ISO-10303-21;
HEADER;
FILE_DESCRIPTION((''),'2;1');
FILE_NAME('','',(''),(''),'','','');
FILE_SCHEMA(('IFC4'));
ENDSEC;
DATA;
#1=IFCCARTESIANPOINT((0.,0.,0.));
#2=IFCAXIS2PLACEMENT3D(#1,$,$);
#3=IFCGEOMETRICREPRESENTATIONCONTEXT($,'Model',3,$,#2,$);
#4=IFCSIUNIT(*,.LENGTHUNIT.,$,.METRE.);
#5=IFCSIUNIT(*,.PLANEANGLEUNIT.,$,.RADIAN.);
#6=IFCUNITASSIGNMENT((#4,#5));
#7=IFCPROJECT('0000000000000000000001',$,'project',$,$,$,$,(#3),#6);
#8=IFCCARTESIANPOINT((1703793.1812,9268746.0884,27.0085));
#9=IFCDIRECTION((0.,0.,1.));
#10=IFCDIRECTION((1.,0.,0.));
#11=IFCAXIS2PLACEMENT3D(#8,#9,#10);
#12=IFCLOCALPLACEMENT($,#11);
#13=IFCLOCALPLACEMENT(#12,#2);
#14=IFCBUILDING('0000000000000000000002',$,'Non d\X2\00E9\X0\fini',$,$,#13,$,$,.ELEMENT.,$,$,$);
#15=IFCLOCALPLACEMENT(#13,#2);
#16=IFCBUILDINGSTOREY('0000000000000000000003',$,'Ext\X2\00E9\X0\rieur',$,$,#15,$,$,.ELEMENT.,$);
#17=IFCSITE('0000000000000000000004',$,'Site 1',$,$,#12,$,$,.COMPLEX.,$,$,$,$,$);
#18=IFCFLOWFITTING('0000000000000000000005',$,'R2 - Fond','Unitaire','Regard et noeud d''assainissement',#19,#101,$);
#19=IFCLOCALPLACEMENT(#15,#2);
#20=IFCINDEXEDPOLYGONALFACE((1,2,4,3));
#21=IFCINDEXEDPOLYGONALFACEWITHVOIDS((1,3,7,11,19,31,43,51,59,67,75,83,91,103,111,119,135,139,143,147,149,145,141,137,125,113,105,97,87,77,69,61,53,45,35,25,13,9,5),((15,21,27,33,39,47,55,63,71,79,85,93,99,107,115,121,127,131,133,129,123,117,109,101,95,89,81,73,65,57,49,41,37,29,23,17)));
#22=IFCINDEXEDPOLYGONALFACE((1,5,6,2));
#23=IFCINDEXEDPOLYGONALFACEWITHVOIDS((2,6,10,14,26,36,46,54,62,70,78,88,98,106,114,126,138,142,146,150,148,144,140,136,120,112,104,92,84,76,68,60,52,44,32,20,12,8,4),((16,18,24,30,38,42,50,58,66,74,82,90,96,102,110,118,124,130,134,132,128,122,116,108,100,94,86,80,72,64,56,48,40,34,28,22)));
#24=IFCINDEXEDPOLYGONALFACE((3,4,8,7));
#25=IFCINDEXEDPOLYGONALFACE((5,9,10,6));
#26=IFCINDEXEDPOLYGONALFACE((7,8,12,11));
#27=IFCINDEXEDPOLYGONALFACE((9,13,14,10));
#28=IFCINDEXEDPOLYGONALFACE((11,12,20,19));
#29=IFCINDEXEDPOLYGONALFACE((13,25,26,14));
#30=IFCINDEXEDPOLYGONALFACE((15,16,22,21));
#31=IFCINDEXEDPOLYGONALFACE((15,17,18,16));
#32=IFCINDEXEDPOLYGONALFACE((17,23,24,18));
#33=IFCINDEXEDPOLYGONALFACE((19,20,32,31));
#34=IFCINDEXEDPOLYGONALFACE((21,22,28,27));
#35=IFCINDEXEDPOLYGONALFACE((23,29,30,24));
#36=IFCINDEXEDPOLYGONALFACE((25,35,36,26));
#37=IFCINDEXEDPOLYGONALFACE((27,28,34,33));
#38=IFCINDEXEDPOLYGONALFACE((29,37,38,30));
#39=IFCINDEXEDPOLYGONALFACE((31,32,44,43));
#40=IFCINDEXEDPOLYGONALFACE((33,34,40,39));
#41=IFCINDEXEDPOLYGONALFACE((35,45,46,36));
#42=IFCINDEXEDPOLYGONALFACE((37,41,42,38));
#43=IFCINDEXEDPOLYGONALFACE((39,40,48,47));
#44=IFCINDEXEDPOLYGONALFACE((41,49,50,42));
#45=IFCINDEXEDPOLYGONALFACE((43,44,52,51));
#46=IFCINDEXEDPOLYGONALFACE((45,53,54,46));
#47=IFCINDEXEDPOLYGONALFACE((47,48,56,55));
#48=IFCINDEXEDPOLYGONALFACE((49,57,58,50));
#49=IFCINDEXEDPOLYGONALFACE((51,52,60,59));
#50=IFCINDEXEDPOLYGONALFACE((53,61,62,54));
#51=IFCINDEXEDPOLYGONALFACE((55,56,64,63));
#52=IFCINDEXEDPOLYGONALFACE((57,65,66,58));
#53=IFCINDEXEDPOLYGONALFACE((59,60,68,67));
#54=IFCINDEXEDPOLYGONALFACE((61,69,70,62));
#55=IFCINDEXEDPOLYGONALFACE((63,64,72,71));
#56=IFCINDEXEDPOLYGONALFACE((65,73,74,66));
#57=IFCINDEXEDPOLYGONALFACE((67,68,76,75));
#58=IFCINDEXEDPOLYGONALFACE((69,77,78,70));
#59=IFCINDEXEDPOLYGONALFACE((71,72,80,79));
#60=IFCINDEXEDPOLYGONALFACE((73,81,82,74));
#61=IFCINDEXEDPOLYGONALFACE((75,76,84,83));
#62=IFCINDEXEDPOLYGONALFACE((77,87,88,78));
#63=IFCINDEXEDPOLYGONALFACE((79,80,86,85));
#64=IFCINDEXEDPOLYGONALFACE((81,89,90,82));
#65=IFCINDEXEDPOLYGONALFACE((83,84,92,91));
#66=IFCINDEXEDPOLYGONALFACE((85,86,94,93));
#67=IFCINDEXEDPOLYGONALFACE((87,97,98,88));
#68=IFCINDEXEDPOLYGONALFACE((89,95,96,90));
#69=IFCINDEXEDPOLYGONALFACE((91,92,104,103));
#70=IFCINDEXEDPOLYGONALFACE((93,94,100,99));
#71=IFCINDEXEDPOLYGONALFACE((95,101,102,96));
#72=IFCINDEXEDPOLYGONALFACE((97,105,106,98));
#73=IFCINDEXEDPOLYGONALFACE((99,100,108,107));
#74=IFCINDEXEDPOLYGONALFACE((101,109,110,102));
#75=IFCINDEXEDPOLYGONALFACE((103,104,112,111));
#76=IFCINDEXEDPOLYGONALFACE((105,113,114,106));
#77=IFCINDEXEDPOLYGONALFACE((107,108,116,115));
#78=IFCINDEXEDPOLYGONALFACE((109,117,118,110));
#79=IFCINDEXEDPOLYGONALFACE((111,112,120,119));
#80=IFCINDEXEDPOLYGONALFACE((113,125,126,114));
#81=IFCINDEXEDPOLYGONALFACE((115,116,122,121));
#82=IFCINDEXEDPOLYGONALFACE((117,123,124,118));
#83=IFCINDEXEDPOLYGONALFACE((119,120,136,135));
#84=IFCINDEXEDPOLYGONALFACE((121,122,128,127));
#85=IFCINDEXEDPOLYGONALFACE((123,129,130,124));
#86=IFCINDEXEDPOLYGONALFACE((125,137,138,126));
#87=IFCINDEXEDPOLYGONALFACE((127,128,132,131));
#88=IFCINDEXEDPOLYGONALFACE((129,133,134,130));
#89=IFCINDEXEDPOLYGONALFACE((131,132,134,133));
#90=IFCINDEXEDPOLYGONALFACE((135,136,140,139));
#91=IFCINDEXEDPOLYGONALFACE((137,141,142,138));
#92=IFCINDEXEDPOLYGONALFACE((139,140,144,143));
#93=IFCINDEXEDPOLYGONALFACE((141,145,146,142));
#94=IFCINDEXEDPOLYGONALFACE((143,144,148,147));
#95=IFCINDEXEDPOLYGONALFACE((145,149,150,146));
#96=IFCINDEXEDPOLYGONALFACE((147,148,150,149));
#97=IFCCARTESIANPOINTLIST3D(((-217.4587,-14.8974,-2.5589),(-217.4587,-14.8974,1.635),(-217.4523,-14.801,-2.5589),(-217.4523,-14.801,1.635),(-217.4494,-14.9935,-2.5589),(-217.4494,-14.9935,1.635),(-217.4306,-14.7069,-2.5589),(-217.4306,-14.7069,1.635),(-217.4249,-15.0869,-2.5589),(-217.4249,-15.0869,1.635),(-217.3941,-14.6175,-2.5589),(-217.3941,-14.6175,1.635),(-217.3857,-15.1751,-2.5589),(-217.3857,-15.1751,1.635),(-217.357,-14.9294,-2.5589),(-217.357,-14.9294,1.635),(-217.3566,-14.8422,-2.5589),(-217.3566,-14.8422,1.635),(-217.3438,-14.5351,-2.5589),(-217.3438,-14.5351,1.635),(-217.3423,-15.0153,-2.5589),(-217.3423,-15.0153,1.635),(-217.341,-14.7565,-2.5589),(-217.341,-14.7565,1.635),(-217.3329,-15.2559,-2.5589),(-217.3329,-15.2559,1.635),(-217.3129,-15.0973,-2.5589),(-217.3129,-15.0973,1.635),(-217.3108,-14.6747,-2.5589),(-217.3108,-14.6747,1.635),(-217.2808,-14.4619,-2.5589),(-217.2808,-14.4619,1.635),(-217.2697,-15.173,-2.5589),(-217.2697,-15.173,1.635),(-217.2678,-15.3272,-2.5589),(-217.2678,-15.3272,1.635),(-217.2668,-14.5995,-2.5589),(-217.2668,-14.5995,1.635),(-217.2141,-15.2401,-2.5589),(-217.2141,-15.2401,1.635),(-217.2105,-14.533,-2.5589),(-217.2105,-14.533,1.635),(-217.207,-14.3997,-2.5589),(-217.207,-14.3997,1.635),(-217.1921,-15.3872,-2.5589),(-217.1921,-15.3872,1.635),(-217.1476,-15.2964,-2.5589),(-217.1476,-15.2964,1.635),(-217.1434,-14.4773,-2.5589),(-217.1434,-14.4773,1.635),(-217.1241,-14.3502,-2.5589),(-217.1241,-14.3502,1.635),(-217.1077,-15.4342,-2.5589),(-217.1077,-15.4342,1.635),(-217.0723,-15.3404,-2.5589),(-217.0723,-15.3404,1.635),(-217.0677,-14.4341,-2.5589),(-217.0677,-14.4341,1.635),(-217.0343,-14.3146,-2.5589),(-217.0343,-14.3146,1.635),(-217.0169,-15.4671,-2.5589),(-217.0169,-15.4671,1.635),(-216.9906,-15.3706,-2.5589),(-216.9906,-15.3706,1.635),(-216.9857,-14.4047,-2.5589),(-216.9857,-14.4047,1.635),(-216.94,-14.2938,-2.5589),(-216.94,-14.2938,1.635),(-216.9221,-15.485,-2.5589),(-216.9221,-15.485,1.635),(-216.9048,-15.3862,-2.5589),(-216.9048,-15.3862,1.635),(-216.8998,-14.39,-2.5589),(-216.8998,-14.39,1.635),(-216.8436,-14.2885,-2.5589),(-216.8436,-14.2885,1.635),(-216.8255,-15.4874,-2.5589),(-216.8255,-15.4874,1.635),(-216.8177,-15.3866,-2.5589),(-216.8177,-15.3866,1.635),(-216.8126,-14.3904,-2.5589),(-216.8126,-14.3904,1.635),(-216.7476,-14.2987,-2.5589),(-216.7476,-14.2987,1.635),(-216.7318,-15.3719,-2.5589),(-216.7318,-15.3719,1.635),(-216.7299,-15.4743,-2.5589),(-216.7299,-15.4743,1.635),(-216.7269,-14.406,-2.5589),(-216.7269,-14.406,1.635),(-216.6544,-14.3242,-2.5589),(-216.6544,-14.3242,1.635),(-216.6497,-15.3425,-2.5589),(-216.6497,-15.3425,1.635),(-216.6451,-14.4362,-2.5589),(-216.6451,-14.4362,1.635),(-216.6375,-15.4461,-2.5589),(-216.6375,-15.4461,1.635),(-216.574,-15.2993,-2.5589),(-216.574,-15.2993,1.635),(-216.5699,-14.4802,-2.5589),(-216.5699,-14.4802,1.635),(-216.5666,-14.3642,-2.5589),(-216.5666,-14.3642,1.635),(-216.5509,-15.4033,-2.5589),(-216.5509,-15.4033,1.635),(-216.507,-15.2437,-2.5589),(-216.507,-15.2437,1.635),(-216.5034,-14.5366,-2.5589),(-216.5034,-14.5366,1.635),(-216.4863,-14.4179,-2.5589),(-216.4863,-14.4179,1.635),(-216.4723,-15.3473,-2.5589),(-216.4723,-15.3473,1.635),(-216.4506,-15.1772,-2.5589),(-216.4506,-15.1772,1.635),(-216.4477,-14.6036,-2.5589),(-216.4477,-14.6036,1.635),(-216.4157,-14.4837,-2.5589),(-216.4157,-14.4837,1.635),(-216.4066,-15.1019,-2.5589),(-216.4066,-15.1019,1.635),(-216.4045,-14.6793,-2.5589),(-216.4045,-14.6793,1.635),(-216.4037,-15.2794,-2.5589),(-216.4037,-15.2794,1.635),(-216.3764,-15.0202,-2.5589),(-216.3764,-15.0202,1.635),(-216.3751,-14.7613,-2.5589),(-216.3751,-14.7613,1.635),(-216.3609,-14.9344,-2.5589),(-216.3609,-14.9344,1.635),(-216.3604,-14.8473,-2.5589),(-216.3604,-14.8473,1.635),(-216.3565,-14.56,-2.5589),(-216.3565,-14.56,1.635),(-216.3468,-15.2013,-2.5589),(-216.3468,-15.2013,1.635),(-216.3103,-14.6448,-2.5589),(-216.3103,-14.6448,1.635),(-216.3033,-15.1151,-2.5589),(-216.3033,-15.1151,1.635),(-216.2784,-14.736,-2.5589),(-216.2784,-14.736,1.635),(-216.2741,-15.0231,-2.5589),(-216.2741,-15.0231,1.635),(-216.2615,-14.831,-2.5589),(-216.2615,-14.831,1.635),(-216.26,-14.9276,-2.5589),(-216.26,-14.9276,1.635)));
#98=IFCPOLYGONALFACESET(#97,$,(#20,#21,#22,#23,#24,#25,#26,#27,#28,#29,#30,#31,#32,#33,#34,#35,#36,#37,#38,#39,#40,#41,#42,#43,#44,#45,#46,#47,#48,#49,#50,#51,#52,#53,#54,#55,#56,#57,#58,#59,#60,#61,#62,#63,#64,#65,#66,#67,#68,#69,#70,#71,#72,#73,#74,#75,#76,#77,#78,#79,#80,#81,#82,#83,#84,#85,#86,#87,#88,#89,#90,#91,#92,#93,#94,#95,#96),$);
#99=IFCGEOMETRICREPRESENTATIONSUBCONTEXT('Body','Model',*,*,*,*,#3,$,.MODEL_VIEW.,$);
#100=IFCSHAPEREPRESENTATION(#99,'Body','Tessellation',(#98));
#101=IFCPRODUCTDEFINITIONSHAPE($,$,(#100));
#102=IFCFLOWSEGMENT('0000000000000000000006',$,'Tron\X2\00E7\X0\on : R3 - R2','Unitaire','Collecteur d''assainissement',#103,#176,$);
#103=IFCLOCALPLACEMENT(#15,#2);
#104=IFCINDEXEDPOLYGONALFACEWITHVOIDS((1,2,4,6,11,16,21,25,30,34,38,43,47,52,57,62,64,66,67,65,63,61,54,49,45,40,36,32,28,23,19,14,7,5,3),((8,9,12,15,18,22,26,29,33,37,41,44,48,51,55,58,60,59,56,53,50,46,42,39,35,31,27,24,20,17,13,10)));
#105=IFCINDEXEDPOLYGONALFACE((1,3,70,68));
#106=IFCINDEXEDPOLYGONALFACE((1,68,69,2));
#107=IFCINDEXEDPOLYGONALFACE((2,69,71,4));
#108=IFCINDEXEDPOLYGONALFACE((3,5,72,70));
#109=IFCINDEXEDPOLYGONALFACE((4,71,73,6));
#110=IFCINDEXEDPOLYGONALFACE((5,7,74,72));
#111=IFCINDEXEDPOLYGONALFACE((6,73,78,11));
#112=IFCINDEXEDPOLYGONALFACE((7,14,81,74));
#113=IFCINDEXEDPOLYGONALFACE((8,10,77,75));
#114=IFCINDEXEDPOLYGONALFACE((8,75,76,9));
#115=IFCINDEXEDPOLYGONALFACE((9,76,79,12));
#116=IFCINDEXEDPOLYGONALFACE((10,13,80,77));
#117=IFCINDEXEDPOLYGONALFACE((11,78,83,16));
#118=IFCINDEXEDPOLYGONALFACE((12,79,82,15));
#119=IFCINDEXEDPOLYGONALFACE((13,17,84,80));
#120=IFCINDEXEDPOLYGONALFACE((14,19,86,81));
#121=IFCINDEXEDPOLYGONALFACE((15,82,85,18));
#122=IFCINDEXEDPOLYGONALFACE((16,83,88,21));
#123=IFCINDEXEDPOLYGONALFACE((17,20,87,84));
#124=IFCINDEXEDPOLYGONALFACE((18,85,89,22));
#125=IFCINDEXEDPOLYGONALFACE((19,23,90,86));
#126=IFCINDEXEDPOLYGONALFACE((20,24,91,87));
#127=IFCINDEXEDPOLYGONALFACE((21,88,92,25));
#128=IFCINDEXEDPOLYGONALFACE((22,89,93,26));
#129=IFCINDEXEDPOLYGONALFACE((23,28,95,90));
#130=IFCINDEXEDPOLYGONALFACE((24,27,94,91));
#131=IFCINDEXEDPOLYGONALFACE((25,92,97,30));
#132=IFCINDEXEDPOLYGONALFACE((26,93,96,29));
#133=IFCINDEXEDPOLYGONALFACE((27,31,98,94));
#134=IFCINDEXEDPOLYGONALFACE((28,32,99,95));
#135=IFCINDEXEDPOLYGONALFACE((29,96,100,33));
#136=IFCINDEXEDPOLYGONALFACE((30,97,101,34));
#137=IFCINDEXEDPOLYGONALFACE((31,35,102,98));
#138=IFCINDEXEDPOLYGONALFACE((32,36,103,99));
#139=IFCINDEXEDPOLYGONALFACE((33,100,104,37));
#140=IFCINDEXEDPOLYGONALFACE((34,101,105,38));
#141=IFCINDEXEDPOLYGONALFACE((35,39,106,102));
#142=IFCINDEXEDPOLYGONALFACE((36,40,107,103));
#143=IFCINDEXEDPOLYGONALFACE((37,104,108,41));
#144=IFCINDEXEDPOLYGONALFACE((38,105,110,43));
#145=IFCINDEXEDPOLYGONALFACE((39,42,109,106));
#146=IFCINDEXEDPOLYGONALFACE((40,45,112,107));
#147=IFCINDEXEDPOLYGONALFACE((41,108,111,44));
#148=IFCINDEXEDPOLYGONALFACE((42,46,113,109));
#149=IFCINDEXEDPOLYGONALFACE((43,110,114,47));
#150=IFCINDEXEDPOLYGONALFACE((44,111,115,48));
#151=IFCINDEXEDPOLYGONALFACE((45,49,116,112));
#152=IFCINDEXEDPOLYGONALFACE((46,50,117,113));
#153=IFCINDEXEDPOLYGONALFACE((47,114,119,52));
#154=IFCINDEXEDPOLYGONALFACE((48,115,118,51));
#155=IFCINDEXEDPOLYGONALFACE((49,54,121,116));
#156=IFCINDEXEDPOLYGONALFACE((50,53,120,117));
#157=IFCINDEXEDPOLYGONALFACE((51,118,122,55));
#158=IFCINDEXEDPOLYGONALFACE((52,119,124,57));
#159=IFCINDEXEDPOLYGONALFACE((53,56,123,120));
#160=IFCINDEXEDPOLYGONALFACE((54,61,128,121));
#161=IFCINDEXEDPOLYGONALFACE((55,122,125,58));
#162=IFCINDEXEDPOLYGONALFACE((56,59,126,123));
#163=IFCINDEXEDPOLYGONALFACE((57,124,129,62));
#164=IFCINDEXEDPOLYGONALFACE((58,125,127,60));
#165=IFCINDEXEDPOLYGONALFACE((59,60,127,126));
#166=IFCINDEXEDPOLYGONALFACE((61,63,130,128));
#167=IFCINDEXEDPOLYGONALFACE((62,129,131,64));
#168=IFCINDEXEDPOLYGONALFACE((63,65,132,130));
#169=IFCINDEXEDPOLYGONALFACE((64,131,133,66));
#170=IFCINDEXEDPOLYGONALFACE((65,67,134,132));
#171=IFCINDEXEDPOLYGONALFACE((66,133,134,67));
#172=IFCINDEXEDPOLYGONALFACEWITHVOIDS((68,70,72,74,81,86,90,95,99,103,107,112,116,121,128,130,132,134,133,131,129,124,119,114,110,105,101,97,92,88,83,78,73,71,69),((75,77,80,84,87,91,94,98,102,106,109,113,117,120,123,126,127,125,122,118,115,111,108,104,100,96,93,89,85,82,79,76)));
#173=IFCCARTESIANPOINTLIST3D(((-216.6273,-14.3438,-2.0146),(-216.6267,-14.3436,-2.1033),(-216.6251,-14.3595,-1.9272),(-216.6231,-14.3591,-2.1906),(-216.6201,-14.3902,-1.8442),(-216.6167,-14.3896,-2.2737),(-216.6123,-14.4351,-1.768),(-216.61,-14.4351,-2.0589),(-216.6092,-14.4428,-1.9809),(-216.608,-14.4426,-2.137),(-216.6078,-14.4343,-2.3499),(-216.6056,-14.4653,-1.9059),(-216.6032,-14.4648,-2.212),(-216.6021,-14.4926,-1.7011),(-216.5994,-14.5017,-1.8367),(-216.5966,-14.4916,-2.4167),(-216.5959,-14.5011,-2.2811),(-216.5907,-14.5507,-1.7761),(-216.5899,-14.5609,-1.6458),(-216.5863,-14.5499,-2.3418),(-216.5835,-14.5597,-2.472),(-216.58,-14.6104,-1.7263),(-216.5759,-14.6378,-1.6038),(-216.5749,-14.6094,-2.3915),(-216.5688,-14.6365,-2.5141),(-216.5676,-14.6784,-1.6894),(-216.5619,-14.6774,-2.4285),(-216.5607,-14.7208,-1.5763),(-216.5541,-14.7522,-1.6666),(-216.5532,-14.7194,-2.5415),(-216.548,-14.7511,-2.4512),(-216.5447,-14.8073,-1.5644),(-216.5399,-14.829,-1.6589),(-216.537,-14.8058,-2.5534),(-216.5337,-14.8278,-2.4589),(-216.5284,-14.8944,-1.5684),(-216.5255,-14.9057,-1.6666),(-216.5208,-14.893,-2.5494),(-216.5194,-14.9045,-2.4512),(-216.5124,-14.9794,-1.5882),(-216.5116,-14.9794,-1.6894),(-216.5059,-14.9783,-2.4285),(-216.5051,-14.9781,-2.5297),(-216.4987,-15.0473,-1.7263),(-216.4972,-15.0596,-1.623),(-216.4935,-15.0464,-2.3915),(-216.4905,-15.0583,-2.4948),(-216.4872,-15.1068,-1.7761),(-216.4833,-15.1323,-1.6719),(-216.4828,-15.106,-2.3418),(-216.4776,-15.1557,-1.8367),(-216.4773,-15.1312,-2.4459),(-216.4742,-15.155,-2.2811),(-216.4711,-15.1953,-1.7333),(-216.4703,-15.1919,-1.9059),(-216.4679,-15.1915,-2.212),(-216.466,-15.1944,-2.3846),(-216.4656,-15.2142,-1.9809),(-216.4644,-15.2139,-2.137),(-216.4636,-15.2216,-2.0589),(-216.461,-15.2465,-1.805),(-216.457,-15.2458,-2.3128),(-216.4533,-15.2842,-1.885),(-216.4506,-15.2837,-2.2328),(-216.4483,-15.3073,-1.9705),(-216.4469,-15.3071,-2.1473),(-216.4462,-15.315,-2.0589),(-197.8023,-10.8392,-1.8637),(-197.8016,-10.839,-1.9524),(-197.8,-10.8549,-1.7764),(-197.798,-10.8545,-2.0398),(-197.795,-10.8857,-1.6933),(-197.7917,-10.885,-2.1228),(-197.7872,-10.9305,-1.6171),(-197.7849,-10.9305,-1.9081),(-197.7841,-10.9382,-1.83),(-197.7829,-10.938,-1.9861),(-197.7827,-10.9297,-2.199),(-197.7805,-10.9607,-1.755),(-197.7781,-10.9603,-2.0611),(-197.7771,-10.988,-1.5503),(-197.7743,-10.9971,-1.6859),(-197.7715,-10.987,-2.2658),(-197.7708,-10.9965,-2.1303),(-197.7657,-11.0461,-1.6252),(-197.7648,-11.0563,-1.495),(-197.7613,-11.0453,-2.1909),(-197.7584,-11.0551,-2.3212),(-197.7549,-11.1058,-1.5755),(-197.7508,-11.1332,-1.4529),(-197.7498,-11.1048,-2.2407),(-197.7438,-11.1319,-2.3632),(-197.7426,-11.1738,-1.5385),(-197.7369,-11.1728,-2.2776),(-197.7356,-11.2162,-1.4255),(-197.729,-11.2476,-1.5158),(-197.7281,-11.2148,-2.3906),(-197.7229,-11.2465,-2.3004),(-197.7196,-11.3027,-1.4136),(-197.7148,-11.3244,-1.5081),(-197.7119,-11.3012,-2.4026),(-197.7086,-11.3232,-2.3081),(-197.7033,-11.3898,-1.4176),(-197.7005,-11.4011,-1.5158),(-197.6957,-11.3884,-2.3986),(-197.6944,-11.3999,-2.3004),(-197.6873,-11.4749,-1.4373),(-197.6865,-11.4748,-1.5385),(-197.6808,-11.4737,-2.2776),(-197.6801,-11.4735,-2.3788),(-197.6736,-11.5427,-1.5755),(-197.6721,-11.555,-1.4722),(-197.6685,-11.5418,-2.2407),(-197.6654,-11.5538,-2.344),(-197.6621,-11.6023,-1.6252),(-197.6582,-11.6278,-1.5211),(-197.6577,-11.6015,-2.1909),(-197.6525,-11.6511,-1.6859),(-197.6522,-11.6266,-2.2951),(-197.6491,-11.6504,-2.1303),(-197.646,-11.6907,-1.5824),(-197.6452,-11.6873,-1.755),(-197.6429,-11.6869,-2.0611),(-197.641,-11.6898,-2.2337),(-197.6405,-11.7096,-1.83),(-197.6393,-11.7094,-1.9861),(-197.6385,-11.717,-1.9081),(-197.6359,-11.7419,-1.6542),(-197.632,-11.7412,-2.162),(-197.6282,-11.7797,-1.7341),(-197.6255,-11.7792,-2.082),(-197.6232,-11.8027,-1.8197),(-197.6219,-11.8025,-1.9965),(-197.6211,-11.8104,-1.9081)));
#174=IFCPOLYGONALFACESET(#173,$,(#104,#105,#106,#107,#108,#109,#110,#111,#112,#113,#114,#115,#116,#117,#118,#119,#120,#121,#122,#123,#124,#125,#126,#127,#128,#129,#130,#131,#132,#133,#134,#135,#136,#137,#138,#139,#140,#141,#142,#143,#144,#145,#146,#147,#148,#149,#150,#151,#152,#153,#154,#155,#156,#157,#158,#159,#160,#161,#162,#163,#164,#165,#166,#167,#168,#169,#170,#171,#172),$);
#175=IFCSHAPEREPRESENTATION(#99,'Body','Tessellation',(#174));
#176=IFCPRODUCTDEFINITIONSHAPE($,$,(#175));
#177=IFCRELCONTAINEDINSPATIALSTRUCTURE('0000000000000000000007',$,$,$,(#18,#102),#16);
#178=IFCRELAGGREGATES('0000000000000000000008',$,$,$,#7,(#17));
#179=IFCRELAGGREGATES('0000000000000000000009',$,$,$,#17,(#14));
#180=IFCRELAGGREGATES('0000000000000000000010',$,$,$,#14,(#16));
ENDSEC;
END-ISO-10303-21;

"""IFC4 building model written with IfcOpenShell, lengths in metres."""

from ifc_helpers import new_model, si_unit, frame, origin, origin_2d, place, context, subcontext, project, spatial, hollow_circle, extrude, element, save


model = new_model("IFC4")

# Units and contexts
model_context = context("Model", 3, world=origin())
body_context = subcontext(model_context, "Body", "Model", "MODEL_VIEW")
ifc_project = project(units=[si_unit("LENGTHUNIT", "METRE"), si_unit("PLANEANGLEUNIT", "RADIAN")], contexts=[model_context])

# Site, building, storey
site_placement = place(None, frame((1703793.1812, 9268746.0884, 27.0085), z_axis=(0.0, 0.0, 1.0), x_axis=(1.0, 0.0, 0.0)))
site = spatial("IfcSite", under=ifc_project, at=site_placement, Name="Site 1", CompositionType="COMPLEX")
building_placement = place(site_placement, origin())
building = spatial("IfcBuilding", under=site, at=building_placement, Name="Non défini", CompositionType="ELEMENT")
storey_placement = place(building_placement, origin())
storey = spatial("IfcBuildingStorey", under=building, at=storey_placement, Name="Extérieur", CompositionType="ELEMENT")

# Flow fitting
flow_fitting_1_placement = place(storey_placement, origin())
element("IfcFlowFitting", 1, at=flow_fitting_1_placement, inside=storey, Name="R2 - Fond", Description="Unitaire", ObjectType="Regard et noeud d'assainissement", context=body_context, shape_type="SweptSolid", body=[
    extrude(hollow_circle(Radius=0.6, WallThickness=0.1, at=origin_2d()), frame((-216.8587, -14.8883, -2.5589), z_axis=(0.0, 0.0, 1.0), x_axis=(0.967224, 0.253924, 0.0)), (0.0, 0.0, 1.0), 4.1939),
])

# Flow segment
flow_segment_1_placement = place(storey_placement, origin())
element("IfcFlowSegment", 2, at=flow_segment_1_placement, inside=storey, Name="Tronçon : R3 - R2", Description="Unitaire", ObjectType="Collecteur d'assainissement", context=body_context, shape_type="SweptSolid", body=[
    extrude(hollow_circle(Radius=0.495, WallThickness=0.095, at=origin_2d()), frame((-197.7117, -11.3238, -1.9081), z_axis=(-0.983078, -0.183015, -0.007877), x_axis=(0.183021, -0.983109, 0.0)), (0.0, 0.0, 1.0), 19.1491),
])

save(model, "model.ifc")
